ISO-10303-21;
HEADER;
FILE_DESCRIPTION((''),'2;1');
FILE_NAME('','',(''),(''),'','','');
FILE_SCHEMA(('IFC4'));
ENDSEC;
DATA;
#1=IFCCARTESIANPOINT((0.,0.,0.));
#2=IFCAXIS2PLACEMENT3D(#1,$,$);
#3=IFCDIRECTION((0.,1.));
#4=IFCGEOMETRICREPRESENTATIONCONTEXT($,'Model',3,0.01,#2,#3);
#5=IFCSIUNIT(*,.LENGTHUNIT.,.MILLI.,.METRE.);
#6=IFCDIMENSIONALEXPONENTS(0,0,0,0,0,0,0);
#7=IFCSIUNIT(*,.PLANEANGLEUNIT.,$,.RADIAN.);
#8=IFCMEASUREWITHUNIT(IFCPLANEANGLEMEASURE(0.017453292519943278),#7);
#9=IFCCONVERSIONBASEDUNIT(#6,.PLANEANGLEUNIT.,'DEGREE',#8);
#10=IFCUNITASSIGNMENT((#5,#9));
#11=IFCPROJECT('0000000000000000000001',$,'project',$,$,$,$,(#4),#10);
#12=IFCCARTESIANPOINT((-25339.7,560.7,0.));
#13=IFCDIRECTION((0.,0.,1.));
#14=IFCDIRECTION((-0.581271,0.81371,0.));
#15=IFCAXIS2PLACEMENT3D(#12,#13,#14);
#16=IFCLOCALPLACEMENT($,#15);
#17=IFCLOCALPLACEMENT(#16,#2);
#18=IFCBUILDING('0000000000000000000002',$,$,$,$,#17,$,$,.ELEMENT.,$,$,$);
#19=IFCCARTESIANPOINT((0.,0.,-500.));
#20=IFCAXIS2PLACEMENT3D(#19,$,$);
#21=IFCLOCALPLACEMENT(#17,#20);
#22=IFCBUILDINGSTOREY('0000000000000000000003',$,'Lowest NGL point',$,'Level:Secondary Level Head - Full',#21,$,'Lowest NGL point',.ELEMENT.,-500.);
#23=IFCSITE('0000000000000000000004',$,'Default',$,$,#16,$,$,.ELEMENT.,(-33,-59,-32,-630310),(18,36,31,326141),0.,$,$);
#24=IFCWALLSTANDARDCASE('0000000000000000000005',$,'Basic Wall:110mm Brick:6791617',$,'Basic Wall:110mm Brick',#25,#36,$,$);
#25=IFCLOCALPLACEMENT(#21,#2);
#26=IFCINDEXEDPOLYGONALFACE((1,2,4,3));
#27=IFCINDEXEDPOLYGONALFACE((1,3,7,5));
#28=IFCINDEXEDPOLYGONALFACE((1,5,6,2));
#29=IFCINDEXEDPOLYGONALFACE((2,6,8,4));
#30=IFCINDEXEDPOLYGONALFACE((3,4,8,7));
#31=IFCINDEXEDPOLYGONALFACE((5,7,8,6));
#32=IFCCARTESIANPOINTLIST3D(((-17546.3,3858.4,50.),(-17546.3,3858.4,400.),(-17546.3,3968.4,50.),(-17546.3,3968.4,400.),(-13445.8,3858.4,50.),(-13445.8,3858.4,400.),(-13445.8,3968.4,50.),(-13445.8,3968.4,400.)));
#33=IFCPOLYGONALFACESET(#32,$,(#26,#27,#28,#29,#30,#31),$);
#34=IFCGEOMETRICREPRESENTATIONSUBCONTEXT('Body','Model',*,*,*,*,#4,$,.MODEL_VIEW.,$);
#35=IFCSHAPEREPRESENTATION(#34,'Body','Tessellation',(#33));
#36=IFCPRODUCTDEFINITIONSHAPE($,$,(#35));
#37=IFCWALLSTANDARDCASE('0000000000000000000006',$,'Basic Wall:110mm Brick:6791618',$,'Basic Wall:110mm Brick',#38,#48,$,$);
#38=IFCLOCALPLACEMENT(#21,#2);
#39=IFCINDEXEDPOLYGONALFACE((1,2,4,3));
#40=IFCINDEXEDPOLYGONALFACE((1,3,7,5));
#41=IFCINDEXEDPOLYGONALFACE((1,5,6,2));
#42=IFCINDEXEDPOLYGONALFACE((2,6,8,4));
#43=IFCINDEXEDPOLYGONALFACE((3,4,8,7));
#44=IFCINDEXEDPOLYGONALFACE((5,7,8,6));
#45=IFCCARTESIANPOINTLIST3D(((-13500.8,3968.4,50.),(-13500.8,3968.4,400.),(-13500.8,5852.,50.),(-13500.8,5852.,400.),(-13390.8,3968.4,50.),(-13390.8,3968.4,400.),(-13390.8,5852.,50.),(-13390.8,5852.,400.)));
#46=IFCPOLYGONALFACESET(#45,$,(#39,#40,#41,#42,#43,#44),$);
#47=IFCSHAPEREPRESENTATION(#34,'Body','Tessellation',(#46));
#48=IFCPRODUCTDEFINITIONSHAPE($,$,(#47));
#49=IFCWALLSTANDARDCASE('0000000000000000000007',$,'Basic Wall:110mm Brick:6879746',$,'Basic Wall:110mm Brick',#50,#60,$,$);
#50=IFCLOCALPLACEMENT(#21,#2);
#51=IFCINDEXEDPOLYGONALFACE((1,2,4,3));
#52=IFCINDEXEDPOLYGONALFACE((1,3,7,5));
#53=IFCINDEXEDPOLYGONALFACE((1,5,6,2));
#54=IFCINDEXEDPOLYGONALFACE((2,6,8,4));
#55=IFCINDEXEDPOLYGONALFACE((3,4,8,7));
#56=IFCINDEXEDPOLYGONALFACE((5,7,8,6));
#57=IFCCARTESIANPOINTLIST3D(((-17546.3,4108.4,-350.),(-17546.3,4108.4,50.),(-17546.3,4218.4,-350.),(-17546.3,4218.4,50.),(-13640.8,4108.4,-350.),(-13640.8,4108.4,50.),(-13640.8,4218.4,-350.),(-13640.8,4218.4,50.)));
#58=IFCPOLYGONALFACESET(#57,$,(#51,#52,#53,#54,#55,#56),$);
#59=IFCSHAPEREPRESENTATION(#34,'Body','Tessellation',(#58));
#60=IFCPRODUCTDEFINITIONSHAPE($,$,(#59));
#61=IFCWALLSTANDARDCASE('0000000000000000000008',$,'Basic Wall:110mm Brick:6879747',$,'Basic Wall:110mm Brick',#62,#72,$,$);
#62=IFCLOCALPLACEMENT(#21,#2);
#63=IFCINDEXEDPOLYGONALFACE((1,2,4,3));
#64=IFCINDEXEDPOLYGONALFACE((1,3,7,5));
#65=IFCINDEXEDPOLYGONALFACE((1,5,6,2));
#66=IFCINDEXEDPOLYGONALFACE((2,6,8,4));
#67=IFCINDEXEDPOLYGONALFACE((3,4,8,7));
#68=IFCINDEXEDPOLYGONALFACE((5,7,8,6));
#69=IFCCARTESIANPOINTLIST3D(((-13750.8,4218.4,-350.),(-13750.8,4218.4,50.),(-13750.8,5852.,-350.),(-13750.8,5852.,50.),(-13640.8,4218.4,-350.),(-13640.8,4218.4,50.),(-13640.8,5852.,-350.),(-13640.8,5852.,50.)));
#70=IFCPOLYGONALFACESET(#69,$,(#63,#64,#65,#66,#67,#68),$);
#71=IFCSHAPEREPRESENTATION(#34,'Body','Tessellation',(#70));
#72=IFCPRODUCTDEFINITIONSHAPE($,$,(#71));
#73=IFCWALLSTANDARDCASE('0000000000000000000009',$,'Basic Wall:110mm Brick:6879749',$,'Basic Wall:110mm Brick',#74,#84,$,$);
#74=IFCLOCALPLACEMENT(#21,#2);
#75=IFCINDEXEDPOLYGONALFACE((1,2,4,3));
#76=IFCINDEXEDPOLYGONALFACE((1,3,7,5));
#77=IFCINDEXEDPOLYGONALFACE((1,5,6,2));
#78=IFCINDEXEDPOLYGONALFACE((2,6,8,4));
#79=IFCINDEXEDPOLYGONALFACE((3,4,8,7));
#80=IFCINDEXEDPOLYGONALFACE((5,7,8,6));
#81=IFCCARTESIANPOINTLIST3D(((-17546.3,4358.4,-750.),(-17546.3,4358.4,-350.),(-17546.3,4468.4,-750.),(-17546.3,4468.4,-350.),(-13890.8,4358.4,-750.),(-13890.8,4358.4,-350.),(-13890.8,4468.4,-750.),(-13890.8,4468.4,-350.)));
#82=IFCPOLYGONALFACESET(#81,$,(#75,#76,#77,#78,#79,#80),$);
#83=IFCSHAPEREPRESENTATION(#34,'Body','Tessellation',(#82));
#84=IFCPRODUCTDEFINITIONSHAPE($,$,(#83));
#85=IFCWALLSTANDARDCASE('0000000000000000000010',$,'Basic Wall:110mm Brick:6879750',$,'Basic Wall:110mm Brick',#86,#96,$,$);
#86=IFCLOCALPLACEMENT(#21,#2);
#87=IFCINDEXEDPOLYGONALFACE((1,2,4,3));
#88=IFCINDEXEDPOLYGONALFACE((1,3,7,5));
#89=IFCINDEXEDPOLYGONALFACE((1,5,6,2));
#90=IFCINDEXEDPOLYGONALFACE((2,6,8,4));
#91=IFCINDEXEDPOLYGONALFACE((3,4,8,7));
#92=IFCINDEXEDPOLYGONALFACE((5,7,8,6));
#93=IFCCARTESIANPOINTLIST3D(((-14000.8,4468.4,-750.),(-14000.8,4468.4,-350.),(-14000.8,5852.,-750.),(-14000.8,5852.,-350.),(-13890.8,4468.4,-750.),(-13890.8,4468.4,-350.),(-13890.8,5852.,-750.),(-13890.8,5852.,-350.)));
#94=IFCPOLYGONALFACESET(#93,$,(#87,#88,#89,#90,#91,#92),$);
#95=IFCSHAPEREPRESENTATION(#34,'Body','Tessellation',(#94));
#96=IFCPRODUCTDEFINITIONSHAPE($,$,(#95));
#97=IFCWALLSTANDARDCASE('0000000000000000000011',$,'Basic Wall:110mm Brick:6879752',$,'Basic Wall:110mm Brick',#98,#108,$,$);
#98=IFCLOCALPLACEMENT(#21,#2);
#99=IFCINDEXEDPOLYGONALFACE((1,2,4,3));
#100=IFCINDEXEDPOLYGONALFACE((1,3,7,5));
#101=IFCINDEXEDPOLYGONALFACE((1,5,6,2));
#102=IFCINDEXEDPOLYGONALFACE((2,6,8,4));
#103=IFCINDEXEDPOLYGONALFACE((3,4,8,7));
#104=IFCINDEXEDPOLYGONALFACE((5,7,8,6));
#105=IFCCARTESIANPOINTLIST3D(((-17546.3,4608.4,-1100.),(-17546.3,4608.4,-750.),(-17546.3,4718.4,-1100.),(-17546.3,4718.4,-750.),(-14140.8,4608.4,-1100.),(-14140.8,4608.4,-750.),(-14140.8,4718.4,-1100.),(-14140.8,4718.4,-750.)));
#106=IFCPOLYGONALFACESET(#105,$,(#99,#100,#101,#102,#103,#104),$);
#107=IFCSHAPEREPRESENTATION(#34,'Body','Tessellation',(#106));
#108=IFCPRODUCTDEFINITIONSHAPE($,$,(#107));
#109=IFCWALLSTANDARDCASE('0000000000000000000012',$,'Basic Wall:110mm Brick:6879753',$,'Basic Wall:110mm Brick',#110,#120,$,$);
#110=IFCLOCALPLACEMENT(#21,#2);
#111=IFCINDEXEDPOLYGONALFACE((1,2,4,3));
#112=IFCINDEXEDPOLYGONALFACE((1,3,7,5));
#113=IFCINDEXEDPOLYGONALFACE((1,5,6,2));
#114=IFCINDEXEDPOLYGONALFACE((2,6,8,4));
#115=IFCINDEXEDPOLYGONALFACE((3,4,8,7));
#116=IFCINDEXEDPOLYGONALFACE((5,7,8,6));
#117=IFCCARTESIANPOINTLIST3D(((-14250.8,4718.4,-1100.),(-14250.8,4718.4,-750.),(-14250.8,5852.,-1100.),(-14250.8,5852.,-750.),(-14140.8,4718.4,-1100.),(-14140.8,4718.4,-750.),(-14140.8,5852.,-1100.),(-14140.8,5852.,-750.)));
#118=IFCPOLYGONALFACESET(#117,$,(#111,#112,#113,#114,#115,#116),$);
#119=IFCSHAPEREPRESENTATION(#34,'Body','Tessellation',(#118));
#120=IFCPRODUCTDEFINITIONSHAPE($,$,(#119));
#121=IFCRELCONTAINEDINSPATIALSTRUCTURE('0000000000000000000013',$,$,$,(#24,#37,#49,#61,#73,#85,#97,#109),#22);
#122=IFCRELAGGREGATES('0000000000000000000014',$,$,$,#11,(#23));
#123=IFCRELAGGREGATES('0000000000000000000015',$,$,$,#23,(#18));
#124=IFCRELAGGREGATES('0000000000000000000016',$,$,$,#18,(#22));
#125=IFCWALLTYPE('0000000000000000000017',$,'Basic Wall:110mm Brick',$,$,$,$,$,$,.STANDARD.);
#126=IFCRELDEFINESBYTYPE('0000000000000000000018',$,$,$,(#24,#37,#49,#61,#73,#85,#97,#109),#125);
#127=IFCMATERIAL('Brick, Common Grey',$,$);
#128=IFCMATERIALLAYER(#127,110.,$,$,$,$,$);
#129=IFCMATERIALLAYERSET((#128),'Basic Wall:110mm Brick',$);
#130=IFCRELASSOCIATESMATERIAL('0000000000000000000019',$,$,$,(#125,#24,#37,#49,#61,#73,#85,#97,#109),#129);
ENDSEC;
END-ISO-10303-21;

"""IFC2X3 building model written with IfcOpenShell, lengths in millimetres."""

from ifc_helpers import new_model, entity, si_unit, converted_unit, direction, frame, frame_2d, origin, place, context, subcontext, project, spatial, polyline, rectangle, extrude, clip, bounded_halfspace, material, layer, layer_set, layer_usage, type_object, element, save


model = new_model("IFC2X3")

# Units and contexts
model_context = context("Model", 3, precision=0.01, world=origin(), true_north=direction((0.0, 1.0)))
body_context = subcontext(model_context, "Body", "Model", "MODEL_VIEW")
ifc_project = project(units=[si_unit("LENGTHUNIT", "METRE", prefix="MILLI"), converted_unit("PLANEANGLEUNIT", "DEGREE", entity("IfcPlaneAngleMeasure", 0.017453292519943278), si_unit("PLANEANGLEUNIT", "RADIAN"), dimensions=[0, 0, 0, 0, 0, 0, 0])], contexts=[model_context])

# Site, building, storey
site_placement = place(None, frame((-25339.7, 560.7, 0.0), z_axis=(0.0, 0.0, 1.0), x_axis=(-0.581271, 0.81371, 0.0)))
site = spatial("IfcSite", under=ifc_project, at=site_placement, Name="Default", CompositionType="ELEMENT", RefLatitude=(-33, -59, -32, -630310), RefLongitude=(18, 36, 31, 326141), RefElevation=0.0)
building_placement = place(site_placement, origin())
building = spatial("IfcBuilding", under=site, at=building_placement, CompositionType="ELEMENT")
storey_placement = place(building_placement, frame((0.0, 0.0, -500.0)))
storey = spatial("IfcBuildingStorey", under=building, at=storey_placement, Name="Lowest NGL point", ObjectType="Level:Secondary Level Head - Full", LongName="Lowest NGL point", CompositionType="ELEMENT", Elevation=-500.0)

# Walls
ifc_material = material(Name="Brick, Common Grey")
ifc_layer = layer(ifc_material, 110.0)
ifc_layer_set = layer_set([ifc_layer], Name="Basic Wall:110mm Brick")
ifc_layer_usage_1 = layer_usage(ifc_layer_set, "AXIS2", "NEGATIVE", 55.0)
wall_type = type_object("IfcWallType", Name="Basic Wall:110mm Brick", PredefinedType="STANDARD", material=ifc_layer_set)
wall_1_placement = place(storey_placement, frame((-17546.3, 3913.4, 50.0)))
element("IfcWallStandardCase", 1, at=wall_1_placement, inside=storey, type_object=wall_type, material=ifc_layer_usage_1, Name="Basic Wall:110mm Brick:6791617", ObjectType="Basic Wall:110mm Brick", context=body_context, shape_type="Clipping", body=[
    clip(extrude(rectangle(XDim=4100.5, YDim=110.0, at=frame_2d((2050.3, 0.0), x_axis=(-1.0, 0.0))), origin(), (0.0, 0.0, 1.0), 350.0), bounded_halfspace(frame((0.0, -55.0, 350.0), z_axis=(0.0, 0.0, -1.0), x_axis=(-1.0, 0.0, 0.0)), True, frame((0.0, -55.0, 350.0)), polyline([(0.0, 0.0), (4100.5, 0.0), (4100.5, 110.0), (4045.5, 110.0), (0.0, 110.0), (0.0, 0.0)]))),
])
ifc_layer_usage_2 = layer_usage(ifc_layer_set, "AXIS2", "NEGATIVE", 55.0)
wall_2_placement = place(storey_placement, frame((-13445.8, 3968.4, 50.0), z_axis=(0.0, 0.0, 1.0), x_axis=(0.0, 1.0, 0.0)))
element("IfcWallStandardCase", 2, at=wall_2_placement, inside=storey, type_object=wall_type, material=ifc_layer_usage_2, Name="Basic Wall:110mm Brick:6791618", ObjectType="Basic Wall:110mm Brick", context=body_context, shape_type="Clipping", body=[
    clip(extrude(rectangle(XDim=1883.7, YDim=110.0, at=frame_2d((941.8, 0.0), x_axis=(-1.0, 0.0))), origin(), (0.0, 0.0, 1.0), 350.0), bounded_halfspace(frame((0.0, -55.0, 350.0), z_axis=(0.0, 0.0, -1.0), x_axis=(0.0, 1.0, 0.0)), True, frame((0.0, -55.0, 350.0)), polyline([(0.0, 0.0), (1883.7, 0.0), (1883.7, 110.0), (0.0, 110.0), (0.0, 55.0), (0.0, 0.0)]))),
])
ifc_layer_usage_3 = layer_usage(ifc_layer_set, "AXIS2", "NEGATIVE", 55.0)
wall_3_placement = place(storey_placement, frame((-17546.3, 4163.4, -350.0)))
element("IfcWallStandardCase", 3, at=wall_3_placement, inside=storey, type_object=wall_type, material=ifc_layer_usage_3, Name="Basic Wall:110mm Brick:6879746", ObjectType="Basic Wall:110mm Brick", context=body_context, shape_type="SweptSolid", body=[
    extrude(rectangle(XDim=3905.5, YDim=110.0, at=frame_2d((1952.8, 0.0), x_axis=(-1.0, 0.0))), origin(), (0.0, 0.0, 1.0), 400.0),
])
ifc_layer_usage_4 = layer_usage(ifc_layer_set, "AXIS2", "NEGATIVE", 55.0)
wall_4_placement = place(storey_placement, frame((-13695.8, 4218.4, -350.0), z_axis=(0.0, 0.0, 1.0), x_axis=(0.0, 1.0, 0.0)))
element("IfcWallStandardCase", 4, at=wall_4_placement, inside=storey, type_object=wall_type, material=ifc_layer_usage_4, Name="Basic Wall:110mm Brick:6879747", ObjectType="Basic Wall:110mm Brick", context=body_context, shape_type="SweptSolid", body=[
    extrude(rectangle(XDim=1633.7, YDim=110.0, at=frame_2d((816.8, 0.0), x_axis=(-1.0, 0.0))), origin(), (0.0, 0.0, 1.0), 400.0),
])
ifc_layer_usage_5 = layer_usage(ifc_layer_set, "AXIS2", "NEGATIVE", 55.0)
wall_5_placement = place(storey_placement, frame((-17546.3, 4413.4, -750.0)))
element("IfcWallStandardCase", 5, at=wall_5_placement, inside=storey, type_object=wall_type, material=ifc_layer_usage_5, Name="Basic Wall:110mm Brick:6879749", ObjectType="Basic Wall:110mm Brick", context=body_context, shape_type="SweptSolid", body=[
    extrude(rectangle(XDim=3655.5, YDim=110.0, at=frame_2d((1827.8, 0.0), x_axis=(-1.0, 0.0))), origin(), (0.0, 0.0, 1.0), 400.0),
])
ifc_layer_usage_6 = layer_usage(ifc_layer_set, "AXIS2", "NEGATIVE", 55.0)
wall_6_placement = place(storey_placement, frame((-13945.8, 4468.4, -750.0), z_axis=(0.0, 0.0, 1.0), x_axis=(0.0, 1.0, 0.0)))
element("IfcWallStandardCase", 6, at=wall_6_placement, inside=storey, type_object=wall_type, material=ifc_layer_usage_6, Name="Basic Wall:110mm Brick:6879750", ObjectType="Basic Wall:110mm Brick", context=body_context, shape_type="SweptSolid", body=[
    extrude(rectangle(XDim=1383.7, YDim=110.0, at=frame_2d((691.8, 0.0), x_axis=(-1.0, 0.0))), origin(), (0.0, 0.0, 1.0), 400.0),
])
ifc_layer_usage_7 = layer_usage(ifc_layer_set, "AXIS2", "NEGATIVE", 55.0)
wall_7_placement = place(storey_placement, frame((-17546.3, 4663.4, -1100.0)))
element("IfcWallStandardCase", 7, at=wall_7_placement, inside=storey, type_object=wall_type, material=ifc_layer_usage_7, Name="Basic Wall:110mm Brick:6879752", ObjectType="Basic Wall:110mm Brick", context=body_context, shape_type="SweptSolid", body=[
    extrude(rectangle(XDim=3405.5, YDim=110.0, at=frame_2d((1702.8, 0.0), x_axis=(-1.0, 0.0))), origin(), (0.0, 0.0, 1.0), 350.0),
])
ifc_layer_usage_8 = layer_usage(ifc_layer_set, "AXIS2", "NEGATIVE", 55.0)
wall_8_placement = place(storey_placement, frame((-14195.8, 4718.4, -1100.0), z_axis=(0.0, 0.0, 1.0), x_axis=(0.0, 1.0, 0.0)))
element("IfcWallStandardCase", 8, at=wall_8_placement, inside=storey, type_object=wall_type, material=ifc_layer_usage_8, Name="Basic Wall:110mm Brick:6879753", ObjectType="Basic Wall:110mm Brick", context=body_context, shape_type="SweptSolid", body=[
    extrude(rectangle(XDim=1133.7, YDim=110.0, at=frame_2d((566.8, 0.0), x_axis=(-1.0, 0.0))), origin(), (0.0, 0.0, 1.0), 350.0),
])

save(model, "model.ifc")
